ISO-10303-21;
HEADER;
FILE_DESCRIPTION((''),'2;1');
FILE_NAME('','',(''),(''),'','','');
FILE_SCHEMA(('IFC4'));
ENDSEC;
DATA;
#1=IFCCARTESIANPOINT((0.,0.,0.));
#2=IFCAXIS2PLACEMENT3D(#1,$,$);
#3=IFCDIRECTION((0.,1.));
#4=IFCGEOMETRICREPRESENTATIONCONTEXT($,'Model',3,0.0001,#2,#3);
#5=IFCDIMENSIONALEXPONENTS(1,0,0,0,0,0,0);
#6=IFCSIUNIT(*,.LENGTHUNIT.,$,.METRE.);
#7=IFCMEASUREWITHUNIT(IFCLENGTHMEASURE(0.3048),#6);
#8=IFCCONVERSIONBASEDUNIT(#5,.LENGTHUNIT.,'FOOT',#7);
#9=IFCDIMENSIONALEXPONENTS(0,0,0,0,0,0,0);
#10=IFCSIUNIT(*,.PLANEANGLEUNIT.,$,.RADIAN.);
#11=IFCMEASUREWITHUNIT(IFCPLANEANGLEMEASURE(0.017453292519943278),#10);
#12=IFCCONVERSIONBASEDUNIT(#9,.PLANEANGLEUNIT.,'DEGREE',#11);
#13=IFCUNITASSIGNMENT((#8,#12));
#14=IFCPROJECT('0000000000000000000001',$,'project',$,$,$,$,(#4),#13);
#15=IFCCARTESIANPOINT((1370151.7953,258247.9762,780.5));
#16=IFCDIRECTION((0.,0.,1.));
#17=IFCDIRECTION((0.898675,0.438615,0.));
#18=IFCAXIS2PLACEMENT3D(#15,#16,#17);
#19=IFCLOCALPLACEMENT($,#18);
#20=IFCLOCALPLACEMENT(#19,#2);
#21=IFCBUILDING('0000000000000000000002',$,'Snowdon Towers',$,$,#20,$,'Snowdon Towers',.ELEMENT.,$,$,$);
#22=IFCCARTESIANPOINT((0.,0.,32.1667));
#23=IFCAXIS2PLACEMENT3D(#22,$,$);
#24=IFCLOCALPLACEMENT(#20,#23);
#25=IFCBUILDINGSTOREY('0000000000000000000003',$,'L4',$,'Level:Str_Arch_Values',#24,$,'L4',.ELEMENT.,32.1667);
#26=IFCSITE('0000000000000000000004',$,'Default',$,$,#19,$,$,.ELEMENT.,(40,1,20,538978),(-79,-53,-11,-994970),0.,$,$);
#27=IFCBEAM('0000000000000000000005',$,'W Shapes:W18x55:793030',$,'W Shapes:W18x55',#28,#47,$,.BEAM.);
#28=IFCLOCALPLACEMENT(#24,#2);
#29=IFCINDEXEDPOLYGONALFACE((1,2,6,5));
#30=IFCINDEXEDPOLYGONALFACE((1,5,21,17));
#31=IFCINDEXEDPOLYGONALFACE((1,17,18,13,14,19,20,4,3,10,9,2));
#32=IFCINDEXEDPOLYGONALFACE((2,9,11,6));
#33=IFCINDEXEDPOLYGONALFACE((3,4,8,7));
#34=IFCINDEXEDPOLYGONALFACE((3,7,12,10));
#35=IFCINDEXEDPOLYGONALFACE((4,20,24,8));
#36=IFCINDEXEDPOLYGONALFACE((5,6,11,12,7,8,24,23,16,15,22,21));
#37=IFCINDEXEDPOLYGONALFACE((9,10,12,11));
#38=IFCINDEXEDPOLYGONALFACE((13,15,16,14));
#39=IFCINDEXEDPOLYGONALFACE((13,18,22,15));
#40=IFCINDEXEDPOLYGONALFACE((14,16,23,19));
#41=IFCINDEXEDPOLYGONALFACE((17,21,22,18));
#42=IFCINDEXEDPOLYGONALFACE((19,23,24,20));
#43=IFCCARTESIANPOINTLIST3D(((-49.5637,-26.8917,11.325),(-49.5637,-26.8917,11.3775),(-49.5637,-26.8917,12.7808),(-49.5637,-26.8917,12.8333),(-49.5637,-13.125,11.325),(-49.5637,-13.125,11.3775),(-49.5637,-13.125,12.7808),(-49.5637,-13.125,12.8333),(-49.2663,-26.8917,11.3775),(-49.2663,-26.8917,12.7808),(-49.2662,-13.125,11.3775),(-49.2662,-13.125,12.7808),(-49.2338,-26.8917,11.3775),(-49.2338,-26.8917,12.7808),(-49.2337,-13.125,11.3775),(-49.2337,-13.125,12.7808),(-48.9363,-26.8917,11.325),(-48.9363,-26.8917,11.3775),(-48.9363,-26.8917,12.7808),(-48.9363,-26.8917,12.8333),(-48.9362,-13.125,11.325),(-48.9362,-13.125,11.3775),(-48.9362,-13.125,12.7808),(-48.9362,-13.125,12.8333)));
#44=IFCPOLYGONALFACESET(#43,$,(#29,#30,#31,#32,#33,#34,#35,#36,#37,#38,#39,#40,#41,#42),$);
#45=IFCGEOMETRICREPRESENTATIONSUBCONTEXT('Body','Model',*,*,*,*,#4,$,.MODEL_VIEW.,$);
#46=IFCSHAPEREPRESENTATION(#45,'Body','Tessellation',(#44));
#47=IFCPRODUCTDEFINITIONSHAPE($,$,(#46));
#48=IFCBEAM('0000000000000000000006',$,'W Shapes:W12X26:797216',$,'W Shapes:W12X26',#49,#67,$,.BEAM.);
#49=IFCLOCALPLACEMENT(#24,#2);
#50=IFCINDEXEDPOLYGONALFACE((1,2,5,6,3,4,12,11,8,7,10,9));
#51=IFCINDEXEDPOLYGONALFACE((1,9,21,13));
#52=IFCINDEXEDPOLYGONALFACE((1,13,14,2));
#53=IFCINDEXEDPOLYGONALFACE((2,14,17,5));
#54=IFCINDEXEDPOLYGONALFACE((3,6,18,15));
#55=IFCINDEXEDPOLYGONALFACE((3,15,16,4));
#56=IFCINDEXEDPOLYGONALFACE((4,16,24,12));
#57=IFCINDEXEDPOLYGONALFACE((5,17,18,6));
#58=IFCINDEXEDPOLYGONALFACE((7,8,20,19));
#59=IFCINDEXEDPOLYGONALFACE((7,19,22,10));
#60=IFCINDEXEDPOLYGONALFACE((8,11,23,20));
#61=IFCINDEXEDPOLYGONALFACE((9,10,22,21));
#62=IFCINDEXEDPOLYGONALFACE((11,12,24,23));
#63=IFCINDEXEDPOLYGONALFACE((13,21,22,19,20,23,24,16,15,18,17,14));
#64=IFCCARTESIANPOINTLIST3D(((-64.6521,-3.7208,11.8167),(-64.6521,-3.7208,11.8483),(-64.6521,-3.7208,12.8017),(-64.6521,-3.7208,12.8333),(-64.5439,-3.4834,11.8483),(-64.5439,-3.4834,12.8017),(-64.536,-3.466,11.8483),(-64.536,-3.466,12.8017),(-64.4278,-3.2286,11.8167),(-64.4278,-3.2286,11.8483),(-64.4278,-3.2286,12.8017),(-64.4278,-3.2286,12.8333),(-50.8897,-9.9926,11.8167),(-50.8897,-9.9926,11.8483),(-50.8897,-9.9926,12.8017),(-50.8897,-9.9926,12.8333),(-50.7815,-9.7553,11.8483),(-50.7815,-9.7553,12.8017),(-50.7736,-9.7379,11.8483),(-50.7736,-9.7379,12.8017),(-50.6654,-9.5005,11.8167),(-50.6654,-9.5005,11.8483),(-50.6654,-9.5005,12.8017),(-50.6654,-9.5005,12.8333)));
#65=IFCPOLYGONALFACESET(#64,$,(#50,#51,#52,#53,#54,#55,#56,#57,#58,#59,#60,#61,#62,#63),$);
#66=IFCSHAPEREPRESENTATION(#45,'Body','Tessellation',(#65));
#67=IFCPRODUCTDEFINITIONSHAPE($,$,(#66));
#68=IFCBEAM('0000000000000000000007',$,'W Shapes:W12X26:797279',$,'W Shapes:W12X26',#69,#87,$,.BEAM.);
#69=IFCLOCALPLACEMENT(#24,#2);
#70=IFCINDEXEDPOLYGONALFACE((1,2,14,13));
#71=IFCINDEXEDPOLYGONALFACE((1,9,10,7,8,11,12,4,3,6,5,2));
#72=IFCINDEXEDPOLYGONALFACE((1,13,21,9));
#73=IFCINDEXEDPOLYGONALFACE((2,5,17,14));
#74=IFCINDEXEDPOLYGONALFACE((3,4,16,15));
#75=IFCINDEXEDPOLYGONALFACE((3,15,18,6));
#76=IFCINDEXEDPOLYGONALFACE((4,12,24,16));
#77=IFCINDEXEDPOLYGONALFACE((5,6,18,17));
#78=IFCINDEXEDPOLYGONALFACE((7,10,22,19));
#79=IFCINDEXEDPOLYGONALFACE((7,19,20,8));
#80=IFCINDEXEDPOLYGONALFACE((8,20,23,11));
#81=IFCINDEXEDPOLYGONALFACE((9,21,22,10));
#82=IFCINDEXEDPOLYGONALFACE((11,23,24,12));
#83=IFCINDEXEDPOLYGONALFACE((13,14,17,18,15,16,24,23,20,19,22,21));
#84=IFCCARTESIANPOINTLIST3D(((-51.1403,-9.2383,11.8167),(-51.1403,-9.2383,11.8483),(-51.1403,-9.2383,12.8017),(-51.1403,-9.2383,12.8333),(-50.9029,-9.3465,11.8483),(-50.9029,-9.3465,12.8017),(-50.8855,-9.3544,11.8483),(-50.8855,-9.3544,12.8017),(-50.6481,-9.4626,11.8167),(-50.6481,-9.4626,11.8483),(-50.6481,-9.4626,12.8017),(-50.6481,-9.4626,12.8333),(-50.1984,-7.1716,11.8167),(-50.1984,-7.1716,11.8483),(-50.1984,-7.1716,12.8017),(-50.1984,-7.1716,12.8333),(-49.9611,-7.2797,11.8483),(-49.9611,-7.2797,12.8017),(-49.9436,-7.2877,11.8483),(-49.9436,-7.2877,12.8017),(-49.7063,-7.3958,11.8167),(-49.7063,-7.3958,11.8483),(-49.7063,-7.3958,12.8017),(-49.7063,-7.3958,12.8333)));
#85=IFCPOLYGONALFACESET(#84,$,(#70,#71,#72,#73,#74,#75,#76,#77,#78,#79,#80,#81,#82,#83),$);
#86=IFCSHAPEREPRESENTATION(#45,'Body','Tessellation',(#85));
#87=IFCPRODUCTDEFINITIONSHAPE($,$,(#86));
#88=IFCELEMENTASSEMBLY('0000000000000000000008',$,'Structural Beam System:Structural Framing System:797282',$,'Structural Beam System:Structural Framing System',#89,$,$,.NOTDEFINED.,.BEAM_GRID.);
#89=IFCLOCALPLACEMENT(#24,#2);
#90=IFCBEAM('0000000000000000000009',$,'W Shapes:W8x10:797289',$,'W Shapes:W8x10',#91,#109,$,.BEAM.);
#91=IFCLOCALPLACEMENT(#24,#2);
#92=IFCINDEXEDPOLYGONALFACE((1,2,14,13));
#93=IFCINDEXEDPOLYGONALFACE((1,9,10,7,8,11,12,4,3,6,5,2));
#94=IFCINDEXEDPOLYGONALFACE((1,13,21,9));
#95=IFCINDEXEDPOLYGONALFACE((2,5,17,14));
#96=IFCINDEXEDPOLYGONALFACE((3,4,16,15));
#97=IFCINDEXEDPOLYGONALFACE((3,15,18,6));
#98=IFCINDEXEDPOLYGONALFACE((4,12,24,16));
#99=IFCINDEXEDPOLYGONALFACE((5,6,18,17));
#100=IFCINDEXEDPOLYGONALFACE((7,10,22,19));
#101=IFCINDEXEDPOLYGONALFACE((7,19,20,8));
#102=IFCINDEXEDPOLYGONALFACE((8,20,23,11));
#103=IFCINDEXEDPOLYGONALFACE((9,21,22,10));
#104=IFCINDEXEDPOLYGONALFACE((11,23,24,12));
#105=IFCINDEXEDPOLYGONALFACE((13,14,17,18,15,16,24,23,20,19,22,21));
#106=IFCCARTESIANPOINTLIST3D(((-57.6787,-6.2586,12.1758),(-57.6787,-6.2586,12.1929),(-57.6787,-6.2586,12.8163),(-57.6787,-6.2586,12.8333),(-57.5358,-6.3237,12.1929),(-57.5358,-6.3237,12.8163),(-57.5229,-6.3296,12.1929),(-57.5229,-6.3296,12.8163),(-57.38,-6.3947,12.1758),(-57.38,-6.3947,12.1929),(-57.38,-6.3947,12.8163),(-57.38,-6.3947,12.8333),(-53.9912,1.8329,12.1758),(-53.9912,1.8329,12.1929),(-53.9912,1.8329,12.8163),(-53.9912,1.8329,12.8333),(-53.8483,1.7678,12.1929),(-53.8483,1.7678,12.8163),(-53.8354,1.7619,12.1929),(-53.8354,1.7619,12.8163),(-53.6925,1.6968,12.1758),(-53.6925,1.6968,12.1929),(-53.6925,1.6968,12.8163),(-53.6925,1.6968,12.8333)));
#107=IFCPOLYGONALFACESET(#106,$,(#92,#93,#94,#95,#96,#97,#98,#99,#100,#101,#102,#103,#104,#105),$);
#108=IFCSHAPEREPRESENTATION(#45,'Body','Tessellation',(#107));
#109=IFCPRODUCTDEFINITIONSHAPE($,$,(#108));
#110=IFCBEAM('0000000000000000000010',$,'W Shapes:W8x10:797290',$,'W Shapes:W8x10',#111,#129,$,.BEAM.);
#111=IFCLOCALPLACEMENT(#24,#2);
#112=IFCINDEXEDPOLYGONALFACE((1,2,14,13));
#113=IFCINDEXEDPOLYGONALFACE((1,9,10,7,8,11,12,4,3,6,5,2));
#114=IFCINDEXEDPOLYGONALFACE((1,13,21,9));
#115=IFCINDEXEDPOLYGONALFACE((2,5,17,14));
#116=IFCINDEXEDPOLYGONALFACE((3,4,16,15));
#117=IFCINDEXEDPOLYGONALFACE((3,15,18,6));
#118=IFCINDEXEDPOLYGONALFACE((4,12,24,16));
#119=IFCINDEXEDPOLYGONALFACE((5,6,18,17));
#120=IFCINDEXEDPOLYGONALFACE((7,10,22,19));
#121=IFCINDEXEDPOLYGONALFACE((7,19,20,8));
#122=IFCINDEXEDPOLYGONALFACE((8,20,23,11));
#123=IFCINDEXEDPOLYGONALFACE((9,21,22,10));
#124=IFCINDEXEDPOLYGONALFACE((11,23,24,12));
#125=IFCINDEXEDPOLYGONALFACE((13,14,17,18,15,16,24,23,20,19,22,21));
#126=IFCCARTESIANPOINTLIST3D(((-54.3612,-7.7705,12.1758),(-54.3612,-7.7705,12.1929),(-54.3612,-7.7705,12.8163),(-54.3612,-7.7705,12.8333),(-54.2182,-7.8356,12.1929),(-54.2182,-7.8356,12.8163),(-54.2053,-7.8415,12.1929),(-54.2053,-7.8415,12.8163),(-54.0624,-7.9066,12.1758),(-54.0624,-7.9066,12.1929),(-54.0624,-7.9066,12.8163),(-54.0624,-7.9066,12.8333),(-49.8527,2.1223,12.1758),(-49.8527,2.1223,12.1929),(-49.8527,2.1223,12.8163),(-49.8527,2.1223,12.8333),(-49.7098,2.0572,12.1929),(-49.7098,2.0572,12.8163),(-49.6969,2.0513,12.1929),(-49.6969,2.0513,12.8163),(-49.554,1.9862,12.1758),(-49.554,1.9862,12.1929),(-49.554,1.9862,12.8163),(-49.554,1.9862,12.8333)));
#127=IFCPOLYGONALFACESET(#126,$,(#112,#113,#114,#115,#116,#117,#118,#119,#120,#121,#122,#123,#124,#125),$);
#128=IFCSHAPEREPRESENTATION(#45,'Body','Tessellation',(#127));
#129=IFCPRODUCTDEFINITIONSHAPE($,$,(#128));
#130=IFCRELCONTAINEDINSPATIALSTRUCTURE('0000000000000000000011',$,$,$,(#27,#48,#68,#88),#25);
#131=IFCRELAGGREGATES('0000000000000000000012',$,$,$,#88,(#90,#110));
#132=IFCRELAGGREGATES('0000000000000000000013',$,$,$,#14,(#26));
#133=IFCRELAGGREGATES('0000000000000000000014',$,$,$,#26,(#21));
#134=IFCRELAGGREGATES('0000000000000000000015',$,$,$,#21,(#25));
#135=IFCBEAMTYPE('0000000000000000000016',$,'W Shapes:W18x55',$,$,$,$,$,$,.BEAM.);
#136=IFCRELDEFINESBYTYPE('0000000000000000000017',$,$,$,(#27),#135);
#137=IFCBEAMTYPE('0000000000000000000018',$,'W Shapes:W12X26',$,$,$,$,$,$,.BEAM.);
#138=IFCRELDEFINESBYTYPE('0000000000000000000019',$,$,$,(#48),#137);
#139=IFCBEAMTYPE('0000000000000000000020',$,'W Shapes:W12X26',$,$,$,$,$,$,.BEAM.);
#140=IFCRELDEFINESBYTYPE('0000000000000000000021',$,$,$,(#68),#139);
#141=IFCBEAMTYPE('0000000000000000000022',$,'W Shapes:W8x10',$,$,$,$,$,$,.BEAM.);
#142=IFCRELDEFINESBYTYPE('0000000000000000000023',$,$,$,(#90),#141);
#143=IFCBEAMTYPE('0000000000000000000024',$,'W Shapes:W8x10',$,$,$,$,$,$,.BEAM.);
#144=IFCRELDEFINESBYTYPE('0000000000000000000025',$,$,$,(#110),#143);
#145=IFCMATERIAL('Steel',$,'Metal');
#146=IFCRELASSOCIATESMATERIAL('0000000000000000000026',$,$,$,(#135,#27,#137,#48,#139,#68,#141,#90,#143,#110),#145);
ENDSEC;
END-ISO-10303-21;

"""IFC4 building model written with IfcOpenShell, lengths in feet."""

from ifc_helpers import new_model, entity, si_unit, converted_unit, direction, frame, origin, place, context, subcontext, project, spatial, indexed_curve, outline, extrude, source, transform, mapped, material, type_object, type_shapes, element, aggregate, save


model = new_model("IFC4")

# Units and contexts
model_context = context("Model", 3, precision=0.0001, world=origin(), true_north=direction((0.0, 1.0)))
body_context = subcontext(model_context, "Body", "Model", "MODEL_VIEW")
ifc_project = project(units=[converted_unit("LENGTHUNIT", "FOOT", entity("IfcLengthMeasure", 0.3048), si_unit("LENGTHUNIT", "METRE"), dimensions=[1, 0, 0, 0, 0, 0, 0]), converted_unit("PLANEANGLEUNIT", "DEGREE", entity("IfcPlaneAngleMeasure", 0.017453292519943278), si_unit("PLANEANGLEUNIT", "RADIAN"), dimensions=[0, 0, 0, 0, 0, 0, 0])], contexts=[model_context])

# Site, building, storey
site_placement = place(None, frame((1370151.7953, 258247.9762, 780.5), z_axis=(0.0, 0.0, 1.0), x_axis=(0.898675, 0.438615, 0.0)))
site = spatial("IfcSite", under=ifc_project, at=site_placement, Name="Default", CompositionType="ELEMENT", RefLatitude=(40, 1, 20, 538978), RefLongitude=(-79, -53, -11, -994970), RefElevation=0.0)
building_placement = place(site_placement, origin())
building = spatial("IfcBuilding", under=site, at=building_placement, Name="Snowdon Towers", LongName="Snowdon Towers", CompositionType="ELEMENT")
storey_placement = place(building_placement, frame((0.0, 0.0, 32.1667)))
storey = spatial("IfcBuildingStorey", under=building, at=storey_placement, Name="L4", ObjectType="Level:Str_Arch_Values", LongName="L4", CompositionType="ELEMENT", Elevation=32.1667)

# Shared definitions
ifc_material = material(Name="Steel", Category="Metal")

# Beams
beam_type_1 = type_object("IfcBeamType", Name="W Shapes:W18x55", PredefinedType="BEAM", material=ifc_material)
shared_shape_1 = source(origin(), body_context, "Body", "SweptSolid", [
    extrude(outline(indexed_curve([(-0.3138, -0.7017), (-0.3138, -0.7542), (0.3138, -0.7542), (0.3138, -0.7017), (0.0162, -0.7017), (0.0162, 0.7017), (0.3138, 0.7017), (0.3138, 0.7542), (-0.3137, 0.7542), (-0.3137, 0.7017), (-0.0163, 0.7017), (-0.0163, -0.7017), (-0.3138, -0.7017)], self_intersect=False)), frame((-7.2292, 0.0, 0.0), z_axis=(-1.0, 0.0, 0.0), x_axis=(0.0, -1.0, 0.0)), (0.0, 0.0, -1.0), 13.7667),
])
type_shapes(beam_type_1, [shared_shape_1])
beam_1_placement = place(storey_placement, frame((-49.25, -20.3542, 12.0792), z_axis=(0.0, 0.0, 1.0), x_axis=(0.0, -1.0, 0.0)))
element("IfcBeam", 1, at=beam_1_placement, inside=storey, type_object=beam_type_1, material=ifc_material, Name="W Shapes:W18x55:793030", ObjectType="W Shapes:W18x55", PredefinedType="BEAM", context=body_context, shape_type="MappedRepresentation", body=[
    mapped(shared_shape_1, transform((0.0, 0.0, 0.0), scale=1.0)),
])
beam_type_2 = type_object("IfcBeamType", Name="W Shapes:W12X26", PredefinedType="BEAM", material=ifc_material)
shared_shape_2 = source(origin(), body_context, "Body", "SweptSolid", [
    extrude(outline(indexed_curve([(-0.2704, -0.4767), (-0.2704, -0.5083), (0.2704, -0.5083), (0.2704, -0.4767), (0.0096, -0.4767), (0.0096, 0.4767), (0.2704, 0.4767), (0.2704, 0.5083), (-0.2704, 0.5083), (-0.2704, 0.4767), (-0.0096, 0.4767), (-0.0096, -0.4767), (-0.2704, -0.4767)], self_intersect=False)), frame((-7.5621, 0.0, 0.0), z_axis=(-1.0, 0.0, 0.0), x_axis=(0.0, -1.0, 0.0)), (0.0, 0.0, -1.0), 15.1242),
])
type_shapes(beam_type_2, [shared_shape_2])
beam_2_placement = place(storey_placement, frame((-57.6588, -6.6106, 12.325), z_axis=(0.0, 0.0, 1.0), x_axis=(0.909961, -0.414693, 0.0)))
element("IfcBeam", 2, at=beam_2_placement, inside=storey, type_object=beam_type_2, material=ifc_material, Name="W Shapes:W12X26:797216", ObjectType="W Shapes:W12X26", PredefinedType="BEAM", context=body_context, shape_type="MappedRepresentation", body=[
    mapped(shared_shape_2, transform((0.0, 0.0, 0.0), scale=1.0)),
])
beam_type_3 = type_object("IfcBeamType", Name="W Shapes:W12X26", PredefinedType="BEAM", material=ifc_material)
shared_shape_3 = source(origin(), body_context, "Body", "SweptSolid", [
    extrude(outline(indexed_curve([(-0.2704, -0.4767), (-0.2704, -0.5083), (0.2704, -0.5083), (0.2704, -0.4767), (0.0096, -0.4767), (0.0096, 0.4767), (0.2704, 0.4767), (0.2704, 0.5083), (-0.2704, 0.5083), (-0.2704, 0.4767), (-0.0096, 0.4767), (-0.0096, -0.4767), (-0.2704, -0.4767)], self_intersect=False)), frame((-0.9796, 0.0, 0.0), z_axis=(-1.0, 0.0, 0.0), x_axis=(0.0, -1.0, 0.0)), (0.0, 0.0, -1.0), 2.2713),
])
type_shapes(beam_type_3, [shared_shape_3])
beam_3_placement = place(storey_placement, frame((-50.488, -8.4591, 12.325), z_axis=(0.0, 0.0, 1.0), x_axis=(0.414693, 0.909961, 0.0)))
element("IfcBeam", 3, at=beam_3_placement, inside=storey, type_object=beam_type_3, material=ifc_material, Name="W Shapes:W12X26:797279", ObjectType="W Shapes:W12X26", PredefinedType="BEAM", context=body_context, shape_type="MappedRepresentation", body=[
    mapped(shared_shape_3, transform((0.0, 0.0, 0.0), scale=1.0)),
])

# Element assembly, beams
assembly_1_placement = place(storey_placement, origin())
assembly_1 = element("IfcElementAssembly", 4, at=assembly_1_placement, inside=storey, Name="Structural Beam System:Structural Framing System:797282", ObjectType="Structural Beam System:Structural Framing System", AssemblyPlace="NOTDEFINED", PredefinedType="BEAM_GRID")
beam_type_4 = type_object("IfcBeamType", Name="W Shapes:W8x10", PredefinedType="BEAM", material=ifc_material)
shared_shape_4 = source(origin(), body_context, "Body", "SweptSolid", [
    extrude(outline(indexed_curve([(-0.1642, -0.3117), (-0.1642, -0.3288), (0.1642, -0.3288), (0.1642, -0.3117), (0.0071, -0.3117), (0.0071, 0.3117), (0.1642, 0.3117), (0.1642, 0.3287), (-0.1642, 0.3287), (-0.1642, 0.3117), (-0.0071, 0.3117), (-0.0071, -0.3117), (-0.1642, -0.3117)], self_intersect=False)), frame((-4.694, 0.0, 0.0), z_axis=(-1.0, 0.0, 0.0), x_axis=(0.0, -1.0, 0.0)), (0.0, 0.0, -1.0), 8.8921),
])
type_shapes(beam_type_4, [shared_shape_4])
beam_4_placement = place(assembly_1_placement, frame((-55.5828, -2.0553, 12.5046), z_axis=(0.0, 0.0, 1.0), x_axis=(0.414693, 0.909961, 0.0)))
beam_4 = element("IfcBeam", 5, at=beam_4_placement, type_object=beam_type_4, material=ifc_material, Name="W Shapes:W8x10:797289", ObjectType="W Shapes:W8x10", PredefinedType="BEAM", context=body_context, shape_type="MappedRepresentation", body=[
    mapped(shared_shape_4, transform((0.0, 0.0, 0.0), scale=1.0)),
])
beam_type_5 = type_object("IfcBeamType", Name="W Shapes:W8x10", PredefinedType="BEAM", material=ifc_material)
shared_shape_5 = source(origin(), body_context, "Body", "SweptSolid", [
    extrude(outline(indexed_curve([(-0.1642, -0.3117), (-0.1642, -0.3288), (0.1642, -0.3288), (0.1642, -0.3117), (0.0071, -0.3117), (0.0071, 0.3117), (0.1642, 0.3117), (0.1642, 0.3287), (-0.1642, 0.3287), (-0.1642, 0.3117), (-0.0071, 0.3117), (-0.0071, -0.3117), (-0.1642, -0.3117)], self_intersect=False)), frame((-5.5247, 0.0, 0.0), z_axis=(-1.0, 0.0, 0.0), x_axis=(0.0, -1.0, 0.0)), (0.0, 0.0, -1.0), 10.8717),
])
type_shapes(beam_type_5, [shared_shape_5])
beam_5_placement = place(assembly_1_placement, frame((-51.9207, -2.8113, 12.5046), z_axis=(0.0, 0.0, 1.0), x_axis=(0.414693, 0.909961, 0.0)))
beam_5 = element("IfcBeam", 6, at=beam_5_placement, type_object=beam_type_5, material=ifc_material, Name="W Shapes:W8x10:797290", ObjectType="W Shapes:W8x10", PredefinedType="BEAM", context=body_context, shape_type="MappedRepresentation", body=[
    mapped(shared_shape_5, transform((0.0, 0.0, 0.0), scale=1.0)),
])
aggregate(assembly_1, [beam_4, beam_5])

save(model, "model.ifc")
